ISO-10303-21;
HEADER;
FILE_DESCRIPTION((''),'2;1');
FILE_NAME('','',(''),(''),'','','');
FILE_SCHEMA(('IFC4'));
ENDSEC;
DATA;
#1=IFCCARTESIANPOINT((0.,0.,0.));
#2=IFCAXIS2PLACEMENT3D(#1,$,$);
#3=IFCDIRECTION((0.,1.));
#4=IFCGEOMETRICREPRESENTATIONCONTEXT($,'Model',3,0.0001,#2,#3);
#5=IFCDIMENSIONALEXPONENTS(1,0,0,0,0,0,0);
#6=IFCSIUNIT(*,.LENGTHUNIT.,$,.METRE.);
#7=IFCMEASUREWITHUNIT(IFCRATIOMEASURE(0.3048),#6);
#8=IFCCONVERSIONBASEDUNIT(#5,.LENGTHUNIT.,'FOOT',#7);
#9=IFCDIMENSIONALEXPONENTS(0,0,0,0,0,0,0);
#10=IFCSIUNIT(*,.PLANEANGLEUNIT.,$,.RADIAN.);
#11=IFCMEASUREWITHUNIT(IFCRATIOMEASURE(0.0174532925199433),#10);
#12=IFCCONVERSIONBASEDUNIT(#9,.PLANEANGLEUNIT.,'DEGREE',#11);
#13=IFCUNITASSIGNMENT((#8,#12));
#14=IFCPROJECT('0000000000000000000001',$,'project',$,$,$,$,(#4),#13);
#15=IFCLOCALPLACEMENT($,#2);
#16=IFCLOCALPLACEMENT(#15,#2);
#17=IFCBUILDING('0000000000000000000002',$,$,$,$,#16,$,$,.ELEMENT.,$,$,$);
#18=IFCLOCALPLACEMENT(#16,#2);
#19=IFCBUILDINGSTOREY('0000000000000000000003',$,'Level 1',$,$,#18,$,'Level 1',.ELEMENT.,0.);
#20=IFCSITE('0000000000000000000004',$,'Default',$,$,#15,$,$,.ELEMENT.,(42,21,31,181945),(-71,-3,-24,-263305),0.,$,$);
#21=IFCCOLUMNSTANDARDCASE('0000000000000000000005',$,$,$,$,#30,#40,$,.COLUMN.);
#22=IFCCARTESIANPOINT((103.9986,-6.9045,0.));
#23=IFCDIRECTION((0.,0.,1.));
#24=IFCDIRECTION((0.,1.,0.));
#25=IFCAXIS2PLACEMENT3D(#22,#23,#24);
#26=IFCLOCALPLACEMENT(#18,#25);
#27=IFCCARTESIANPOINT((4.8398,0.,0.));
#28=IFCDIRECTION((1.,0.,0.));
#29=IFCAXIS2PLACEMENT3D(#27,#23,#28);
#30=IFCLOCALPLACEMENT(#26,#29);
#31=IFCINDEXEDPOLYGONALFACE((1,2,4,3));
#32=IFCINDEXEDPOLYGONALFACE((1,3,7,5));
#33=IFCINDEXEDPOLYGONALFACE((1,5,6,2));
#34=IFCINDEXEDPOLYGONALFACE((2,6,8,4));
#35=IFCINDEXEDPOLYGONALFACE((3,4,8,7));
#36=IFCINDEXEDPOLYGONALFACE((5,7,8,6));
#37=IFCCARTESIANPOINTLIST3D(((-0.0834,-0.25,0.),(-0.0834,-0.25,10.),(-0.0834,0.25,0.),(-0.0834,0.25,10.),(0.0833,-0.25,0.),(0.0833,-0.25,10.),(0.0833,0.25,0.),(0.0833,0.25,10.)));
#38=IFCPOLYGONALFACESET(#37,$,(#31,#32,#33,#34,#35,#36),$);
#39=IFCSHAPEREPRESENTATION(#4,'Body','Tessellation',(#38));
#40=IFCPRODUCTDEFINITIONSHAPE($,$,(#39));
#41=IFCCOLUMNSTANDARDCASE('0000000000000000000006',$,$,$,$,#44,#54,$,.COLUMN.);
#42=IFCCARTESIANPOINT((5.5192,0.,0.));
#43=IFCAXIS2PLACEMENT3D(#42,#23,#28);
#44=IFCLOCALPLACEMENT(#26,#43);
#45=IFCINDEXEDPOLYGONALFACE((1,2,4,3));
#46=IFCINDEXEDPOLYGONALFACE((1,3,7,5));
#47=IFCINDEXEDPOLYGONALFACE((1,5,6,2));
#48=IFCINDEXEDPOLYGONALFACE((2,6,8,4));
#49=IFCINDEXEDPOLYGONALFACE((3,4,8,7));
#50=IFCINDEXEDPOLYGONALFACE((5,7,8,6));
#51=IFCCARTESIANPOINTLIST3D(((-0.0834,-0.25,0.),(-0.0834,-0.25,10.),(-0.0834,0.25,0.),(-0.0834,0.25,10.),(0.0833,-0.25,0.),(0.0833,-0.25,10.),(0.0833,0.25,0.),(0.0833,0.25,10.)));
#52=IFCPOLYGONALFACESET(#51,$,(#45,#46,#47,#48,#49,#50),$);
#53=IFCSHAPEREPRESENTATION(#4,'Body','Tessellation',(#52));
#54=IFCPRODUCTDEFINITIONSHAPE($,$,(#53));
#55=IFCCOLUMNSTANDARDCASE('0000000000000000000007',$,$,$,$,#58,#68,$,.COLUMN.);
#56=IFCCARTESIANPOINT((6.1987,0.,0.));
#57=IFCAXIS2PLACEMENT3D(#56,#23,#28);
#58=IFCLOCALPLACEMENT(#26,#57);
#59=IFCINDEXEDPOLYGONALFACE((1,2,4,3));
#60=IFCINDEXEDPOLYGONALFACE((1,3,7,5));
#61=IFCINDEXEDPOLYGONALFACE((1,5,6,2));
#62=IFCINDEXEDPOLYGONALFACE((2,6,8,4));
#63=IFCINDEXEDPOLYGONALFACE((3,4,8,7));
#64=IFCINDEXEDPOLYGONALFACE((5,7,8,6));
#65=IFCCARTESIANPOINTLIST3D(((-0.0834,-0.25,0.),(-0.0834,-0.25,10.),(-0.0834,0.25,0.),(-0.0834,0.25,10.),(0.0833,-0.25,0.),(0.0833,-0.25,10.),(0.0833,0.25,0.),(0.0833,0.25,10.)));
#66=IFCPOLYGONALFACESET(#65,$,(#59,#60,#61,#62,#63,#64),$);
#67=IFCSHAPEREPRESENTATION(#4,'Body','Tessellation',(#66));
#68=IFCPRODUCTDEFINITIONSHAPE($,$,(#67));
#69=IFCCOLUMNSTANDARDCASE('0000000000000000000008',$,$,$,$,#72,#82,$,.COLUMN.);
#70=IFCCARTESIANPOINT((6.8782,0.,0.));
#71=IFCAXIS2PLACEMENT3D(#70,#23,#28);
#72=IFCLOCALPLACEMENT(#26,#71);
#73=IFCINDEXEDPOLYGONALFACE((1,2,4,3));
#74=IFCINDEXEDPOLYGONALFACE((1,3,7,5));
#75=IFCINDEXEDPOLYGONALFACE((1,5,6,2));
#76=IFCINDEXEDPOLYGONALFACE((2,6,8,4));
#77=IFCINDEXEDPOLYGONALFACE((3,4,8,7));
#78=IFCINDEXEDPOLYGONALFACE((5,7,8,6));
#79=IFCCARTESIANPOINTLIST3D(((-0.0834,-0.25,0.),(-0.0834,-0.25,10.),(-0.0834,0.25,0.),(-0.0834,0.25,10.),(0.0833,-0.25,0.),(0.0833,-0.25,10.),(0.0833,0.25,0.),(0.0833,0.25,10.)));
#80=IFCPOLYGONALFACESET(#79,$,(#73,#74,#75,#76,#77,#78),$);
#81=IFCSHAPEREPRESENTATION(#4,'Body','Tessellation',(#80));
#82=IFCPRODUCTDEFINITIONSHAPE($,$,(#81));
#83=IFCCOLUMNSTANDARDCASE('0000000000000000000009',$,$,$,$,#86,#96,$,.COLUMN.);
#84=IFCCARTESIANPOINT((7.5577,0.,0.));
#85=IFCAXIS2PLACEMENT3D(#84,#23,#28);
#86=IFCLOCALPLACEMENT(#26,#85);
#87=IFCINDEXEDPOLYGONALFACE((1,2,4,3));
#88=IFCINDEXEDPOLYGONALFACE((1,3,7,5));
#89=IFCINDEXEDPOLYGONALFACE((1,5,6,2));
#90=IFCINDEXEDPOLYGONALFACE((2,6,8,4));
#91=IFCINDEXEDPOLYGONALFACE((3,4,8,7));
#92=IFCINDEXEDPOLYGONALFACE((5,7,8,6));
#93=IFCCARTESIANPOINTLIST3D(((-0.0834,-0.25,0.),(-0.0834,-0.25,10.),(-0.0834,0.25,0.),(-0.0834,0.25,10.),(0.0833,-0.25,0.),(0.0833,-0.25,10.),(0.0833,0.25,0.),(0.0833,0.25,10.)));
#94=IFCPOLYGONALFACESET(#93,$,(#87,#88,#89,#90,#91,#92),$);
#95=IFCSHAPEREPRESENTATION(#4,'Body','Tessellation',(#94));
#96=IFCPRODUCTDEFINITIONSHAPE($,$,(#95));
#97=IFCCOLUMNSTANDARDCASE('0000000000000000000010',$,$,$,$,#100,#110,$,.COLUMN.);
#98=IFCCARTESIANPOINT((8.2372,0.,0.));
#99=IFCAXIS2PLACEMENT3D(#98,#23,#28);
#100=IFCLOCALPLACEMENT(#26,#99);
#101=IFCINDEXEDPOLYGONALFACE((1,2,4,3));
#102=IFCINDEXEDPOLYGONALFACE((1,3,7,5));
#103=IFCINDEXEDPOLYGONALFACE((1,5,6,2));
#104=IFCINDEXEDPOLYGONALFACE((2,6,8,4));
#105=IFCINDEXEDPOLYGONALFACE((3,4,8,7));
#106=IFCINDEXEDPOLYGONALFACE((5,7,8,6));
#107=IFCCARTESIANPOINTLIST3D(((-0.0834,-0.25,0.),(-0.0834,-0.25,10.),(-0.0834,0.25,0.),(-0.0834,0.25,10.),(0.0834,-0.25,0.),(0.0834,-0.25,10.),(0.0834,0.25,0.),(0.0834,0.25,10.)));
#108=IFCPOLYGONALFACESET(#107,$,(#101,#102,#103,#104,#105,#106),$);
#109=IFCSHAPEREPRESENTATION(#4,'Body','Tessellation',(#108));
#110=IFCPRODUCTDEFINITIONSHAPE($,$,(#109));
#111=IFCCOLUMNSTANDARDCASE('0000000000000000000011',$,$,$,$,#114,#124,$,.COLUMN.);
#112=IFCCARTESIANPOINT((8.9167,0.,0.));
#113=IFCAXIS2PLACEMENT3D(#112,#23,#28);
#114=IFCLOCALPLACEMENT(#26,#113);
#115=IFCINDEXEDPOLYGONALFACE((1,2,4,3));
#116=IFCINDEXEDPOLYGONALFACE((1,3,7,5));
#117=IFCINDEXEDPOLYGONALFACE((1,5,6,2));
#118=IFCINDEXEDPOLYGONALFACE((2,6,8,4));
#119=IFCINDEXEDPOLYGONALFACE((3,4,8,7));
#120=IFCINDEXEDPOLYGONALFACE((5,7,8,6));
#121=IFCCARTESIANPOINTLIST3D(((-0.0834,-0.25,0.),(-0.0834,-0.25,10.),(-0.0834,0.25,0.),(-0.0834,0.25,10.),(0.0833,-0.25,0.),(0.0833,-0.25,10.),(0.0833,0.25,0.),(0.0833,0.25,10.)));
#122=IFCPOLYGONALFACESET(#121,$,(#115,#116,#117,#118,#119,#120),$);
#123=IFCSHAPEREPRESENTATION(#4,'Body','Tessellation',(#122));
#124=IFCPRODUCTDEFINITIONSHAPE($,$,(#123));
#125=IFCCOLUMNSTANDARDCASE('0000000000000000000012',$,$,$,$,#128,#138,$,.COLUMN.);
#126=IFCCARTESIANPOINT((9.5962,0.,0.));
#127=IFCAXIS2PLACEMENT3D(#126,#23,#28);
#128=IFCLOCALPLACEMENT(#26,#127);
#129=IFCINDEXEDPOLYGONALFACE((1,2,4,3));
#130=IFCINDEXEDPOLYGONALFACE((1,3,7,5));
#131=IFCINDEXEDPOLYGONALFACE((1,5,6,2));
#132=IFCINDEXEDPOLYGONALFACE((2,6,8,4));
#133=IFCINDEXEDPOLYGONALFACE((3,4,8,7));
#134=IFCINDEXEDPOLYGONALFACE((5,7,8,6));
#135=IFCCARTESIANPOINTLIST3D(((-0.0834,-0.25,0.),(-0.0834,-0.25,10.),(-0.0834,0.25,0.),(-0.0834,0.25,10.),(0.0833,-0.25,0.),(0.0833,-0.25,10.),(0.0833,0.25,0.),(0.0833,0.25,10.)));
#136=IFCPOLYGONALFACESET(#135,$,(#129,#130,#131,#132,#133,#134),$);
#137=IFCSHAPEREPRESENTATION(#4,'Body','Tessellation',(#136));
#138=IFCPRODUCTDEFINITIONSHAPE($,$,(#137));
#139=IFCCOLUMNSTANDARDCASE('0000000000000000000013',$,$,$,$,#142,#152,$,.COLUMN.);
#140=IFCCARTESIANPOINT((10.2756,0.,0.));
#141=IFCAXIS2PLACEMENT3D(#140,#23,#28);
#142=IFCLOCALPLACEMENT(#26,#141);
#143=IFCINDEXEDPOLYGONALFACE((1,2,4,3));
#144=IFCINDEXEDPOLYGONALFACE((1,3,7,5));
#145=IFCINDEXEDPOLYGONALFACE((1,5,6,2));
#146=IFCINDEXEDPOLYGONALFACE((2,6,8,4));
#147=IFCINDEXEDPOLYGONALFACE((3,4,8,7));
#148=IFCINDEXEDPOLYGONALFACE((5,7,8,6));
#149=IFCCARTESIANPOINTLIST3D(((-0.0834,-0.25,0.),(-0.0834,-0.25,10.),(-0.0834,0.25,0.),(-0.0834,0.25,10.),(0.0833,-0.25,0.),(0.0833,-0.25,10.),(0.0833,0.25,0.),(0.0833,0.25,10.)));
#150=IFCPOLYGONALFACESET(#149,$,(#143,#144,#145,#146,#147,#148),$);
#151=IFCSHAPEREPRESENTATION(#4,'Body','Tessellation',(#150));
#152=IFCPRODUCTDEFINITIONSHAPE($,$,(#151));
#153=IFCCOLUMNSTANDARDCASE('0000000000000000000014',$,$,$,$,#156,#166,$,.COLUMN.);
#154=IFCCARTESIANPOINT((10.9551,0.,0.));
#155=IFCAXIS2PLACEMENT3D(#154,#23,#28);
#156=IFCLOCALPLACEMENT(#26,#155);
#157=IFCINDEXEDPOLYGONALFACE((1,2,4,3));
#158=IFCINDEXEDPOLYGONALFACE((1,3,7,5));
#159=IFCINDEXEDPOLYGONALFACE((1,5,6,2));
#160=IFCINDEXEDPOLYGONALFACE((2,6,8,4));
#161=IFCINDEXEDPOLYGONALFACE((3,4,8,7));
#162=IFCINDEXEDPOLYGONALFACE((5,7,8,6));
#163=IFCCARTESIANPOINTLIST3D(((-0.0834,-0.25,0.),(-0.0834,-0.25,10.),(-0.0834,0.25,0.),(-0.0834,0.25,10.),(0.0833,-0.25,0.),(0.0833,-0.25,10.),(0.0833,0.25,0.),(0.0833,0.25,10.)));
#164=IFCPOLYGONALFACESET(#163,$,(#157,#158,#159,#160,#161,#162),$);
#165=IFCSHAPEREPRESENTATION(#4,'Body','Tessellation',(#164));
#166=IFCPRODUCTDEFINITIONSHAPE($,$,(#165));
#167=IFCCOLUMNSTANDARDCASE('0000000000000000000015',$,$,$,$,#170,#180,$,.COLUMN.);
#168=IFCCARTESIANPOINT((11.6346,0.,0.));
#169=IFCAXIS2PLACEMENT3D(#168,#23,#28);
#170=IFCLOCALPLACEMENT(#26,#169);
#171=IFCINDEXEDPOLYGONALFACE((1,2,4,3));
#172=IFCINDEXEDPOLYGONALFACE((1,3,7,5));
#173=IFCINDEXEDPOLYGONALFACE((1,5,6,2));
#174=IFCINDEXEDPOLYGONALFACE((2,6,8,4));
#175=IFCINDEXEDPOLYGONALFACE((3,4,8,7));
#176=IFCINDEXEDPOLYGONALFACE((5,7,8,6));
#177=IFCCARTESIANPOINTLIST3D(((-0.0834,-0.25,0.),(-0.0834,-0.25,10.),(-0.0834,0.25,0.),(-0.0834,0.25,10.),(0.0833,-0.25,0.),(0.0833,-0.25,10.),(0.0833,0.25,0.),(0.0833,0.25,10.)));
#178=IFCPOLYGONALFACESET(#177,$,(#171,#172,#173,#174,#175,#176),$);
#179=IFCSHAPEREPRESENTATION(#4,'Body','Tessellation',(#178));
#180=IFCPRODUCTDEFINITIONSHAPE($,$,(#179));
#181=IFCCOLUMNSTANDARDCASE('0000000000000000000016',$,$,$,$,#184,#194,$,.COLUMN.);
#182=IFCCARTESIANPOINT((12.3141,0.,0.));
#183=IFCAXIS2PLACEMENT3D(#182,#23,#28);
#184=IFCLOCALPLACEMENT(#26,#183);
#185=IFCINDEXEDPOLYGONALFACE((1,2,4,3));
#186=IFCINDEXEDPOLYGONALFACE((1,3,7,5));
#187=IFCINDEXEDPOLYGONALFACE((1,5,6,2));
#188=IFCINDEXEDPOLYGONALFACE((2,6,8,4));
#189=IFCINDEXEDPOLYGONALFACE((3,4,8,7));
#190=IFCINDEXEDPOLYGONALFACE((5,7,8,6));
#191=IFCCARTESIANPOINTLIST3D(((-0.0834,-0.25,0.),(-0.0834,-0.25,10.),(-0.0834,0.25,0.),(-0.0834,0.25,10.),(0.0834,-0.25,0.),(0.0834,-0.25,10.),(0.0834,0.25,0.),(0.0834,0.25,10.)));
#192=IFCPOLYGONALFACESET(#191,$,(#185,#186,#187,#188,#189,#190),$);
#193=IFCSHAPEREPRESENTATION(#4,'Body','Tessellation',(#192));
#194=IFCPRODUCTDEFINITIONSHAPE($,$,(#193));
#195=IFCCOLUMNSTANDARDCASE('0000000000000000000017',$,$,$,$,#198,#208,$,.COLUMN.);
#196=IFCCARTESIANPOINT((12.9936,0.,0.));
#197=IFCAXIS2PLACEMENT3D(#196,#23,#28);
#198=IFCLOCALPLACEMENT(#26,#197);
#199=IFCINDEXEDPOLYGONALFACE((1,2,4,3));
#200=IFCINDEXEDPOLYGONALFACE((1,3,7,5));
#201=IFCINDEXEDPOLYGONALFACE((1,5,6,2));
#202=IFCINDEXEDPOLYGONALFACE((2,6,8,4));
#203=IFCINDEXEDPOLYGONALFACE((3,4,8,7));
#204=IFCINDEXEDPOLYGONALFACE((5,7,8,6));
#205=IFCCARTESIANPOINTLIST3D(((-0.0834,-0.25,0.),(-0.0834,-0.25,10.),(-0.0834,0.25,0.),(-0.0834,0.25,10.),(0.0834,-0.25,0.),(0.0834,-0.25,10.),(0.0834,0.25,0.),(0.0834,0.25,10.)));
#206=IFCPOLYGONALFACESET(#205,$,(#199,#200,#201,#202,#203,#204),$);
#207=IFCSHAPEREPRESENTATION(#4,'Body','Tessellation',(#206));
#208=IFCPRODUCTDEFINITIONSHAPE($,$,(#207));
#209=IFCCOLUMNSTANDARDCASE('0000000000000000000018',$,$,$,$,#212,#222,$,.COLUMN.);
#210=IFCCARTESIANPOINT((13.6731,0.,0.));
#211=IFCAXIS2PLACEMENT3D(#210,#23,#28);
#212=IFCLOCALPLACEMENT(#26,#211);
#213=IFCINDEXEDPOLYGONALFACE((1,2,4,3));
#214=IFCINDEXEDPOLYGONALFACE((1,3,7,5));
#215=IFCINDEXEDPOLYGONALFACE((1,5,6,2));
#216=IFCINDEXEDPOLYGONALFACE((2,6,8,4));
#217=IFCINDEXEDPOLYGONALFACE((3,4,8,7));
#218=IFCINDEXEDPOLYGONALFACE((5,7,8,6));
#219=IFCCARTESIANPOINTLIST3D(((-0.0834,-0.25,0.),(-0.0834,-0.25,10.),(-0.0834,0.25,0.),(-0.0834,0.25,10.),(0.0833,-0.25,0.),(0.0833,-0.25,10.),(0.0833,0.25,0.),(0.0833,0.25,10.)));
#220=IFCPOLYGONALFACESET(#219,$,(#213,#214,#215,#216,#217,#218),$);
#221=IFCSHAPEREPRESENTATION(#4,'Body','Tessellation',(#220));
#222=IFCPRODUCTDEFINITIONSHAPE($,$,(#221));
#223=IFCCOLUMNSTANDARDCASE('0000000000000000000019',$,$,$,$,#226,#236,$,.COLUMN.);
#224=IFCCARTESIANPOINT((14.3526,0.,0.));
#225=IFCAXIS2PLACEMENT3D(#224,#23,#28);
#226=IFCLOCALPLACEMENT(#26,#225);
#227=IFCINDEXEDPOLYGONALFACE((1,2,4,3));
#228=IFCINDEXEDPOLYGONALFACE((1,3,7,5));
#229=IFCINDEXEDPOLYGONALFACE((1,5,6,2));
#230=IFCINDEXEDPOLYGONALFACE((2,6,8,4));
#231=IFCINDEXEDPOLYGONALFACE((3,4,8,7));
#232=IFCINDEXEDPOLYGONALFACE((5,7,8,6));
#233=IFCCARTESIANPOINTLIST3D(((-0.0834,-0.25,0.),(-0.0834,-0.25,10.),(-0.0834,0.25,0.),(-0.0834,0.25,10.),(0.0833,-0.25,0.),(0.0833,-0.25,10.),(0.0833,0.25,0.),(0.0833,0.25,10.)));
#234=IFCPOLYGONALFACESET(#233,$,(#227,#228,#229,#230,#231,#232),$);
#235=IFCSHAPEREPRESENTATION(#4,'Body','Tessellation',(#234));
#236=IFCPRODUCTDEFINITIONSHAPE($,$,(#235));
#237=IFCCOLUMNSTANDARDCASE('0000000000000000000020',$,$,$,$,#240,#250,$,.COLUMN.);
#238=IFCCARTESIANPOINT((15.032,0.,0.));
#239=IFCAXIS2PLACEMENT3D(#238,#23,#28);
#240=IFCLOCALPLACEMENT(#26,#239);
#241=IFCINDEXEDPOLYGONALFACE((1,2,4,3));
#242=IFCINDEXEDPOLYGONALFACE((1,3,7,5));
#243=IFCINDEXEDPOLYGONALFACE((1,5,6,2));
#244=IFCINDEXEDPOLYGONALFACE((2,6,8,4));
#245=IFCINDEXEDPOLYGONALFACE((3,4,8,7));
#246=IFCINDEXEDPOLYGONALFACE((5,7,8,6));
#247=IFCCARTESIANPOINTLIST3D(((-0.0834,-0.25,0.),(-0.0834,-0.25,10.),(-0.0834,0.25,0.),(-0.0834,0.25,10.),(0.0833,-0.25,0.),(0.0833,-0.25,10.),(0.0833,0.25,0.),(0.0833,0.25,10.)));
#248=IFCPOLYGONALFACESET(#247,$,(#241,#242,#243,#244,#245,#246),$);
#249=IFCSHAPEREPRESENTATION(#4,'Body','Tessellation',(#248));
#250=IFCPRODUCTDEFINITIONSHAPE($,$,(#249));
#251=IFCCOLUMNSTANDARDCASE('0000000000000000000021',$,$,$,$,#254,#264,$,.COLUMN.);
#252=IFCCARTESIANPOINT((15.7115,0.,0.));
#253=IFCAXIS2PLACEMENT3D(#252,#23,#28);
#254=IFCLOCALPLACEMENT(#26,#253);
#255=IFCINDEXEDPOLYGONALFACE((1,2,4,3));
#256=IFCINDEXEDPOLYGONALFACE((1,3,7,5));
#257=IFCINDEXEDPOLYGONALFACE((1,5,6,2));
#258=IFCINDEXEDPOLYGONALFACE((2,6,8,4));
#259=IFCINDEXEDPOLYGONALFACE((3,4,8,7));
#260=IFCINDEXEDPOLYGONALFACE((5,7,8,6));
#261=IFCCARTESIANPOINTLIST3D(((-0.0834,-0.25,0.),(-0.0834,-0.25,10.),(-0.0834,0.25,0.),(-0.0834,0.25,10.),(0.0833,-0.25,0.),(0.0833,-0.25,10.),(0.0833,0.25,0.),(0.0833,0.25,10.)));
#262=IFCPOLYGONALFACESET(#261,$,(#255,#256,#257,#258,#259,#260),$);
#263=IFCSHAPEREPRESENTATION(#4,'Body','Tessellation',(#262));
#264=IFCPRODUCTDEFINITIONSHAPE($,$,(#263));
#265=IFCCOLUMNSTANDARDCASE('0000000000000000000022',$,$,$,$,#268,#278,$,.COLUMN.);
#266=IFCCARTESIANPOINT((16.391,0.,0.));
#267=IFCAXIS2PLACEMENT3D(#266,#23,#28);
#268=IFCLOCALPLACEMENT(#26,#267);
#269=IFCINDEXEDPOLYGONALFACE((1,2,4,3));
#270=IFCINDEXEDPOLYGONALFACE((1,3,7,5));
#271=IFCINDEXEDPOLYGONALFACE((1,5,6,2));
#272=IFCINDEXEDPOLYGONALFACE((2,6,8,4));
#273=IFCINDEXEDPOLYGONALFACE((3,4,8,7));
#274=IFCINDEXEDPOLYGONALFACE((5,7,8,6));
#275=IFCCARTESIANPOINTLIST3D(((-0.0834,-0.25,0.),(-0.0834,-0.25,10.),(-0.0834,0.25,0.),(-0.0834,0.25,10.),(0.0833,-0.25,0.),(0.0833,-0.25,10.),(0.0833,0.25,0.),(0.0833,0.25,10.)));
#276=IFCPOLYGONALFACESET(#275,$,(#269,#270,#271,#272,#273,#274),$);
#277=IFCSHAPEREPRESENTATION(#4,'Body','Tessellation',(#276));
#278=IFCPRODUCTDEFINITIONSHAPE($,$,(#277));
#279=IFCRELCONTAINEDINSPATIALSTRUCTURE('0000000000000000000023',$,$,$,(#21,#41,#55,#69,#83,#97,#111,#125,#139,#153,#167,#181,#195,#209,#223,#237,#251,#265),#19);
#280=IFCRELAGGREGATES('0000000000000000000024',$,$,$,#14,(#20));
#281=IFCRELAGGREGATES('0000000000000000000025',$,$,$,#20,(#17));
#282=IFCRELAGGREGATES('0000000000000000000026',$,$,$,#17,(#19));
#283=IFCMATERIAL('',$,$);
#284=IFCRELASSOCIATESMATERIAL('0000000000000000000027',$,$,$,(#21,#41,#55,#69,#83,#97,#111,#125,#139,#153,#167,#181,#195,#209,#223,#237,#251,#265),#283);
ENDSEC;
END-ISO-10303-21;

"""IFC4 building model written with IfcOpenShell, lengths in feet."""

from ifc_helpers import new_model, entity, si_unit, converted_unit, direction, frame, origin, place, context, project, spatial, rectangle, extrude, material, element, save


model = new_model("IFC4")

# Units and contexts
model_context = context("Model", 3, precision=0.0001, world=origin(), true_north=direction((0.0, 1.0)))
ifc_project = project(units=[converted_unit("LENGTHUNIT", "FOOT", entity("IfcRatioMeasure", 0.3048), si_unit("LENGTHUNIT", "METRE"), dimensions=[1, 0, 0, 0, 0, 0, 0]), converted_unit("PLANEANGLEUNIT", "DEGREE", entity("IfcRatioMeasure", 0.0174532925199433), si_unit("PLANEANGLEUNIT", "RADIAN"), dimensions=[0, 0, 0, 0, 0, 0, 0])], contexts=[model_context])

# Site, building, storey
site_placement = place(None, origin())
site = spatial("IfcSite", under=ifc_project, at=site_placement, Name="Default", CompositionType="ELEMENT", RefLatitude=(42, 21, 31, 181945), RefLongitude=(-71, -3, -24, -263305), RefElevation=0.0)
building_placement = place(site_placement, origin())
building = spatial("IfcBuilding", under=site, at=building_placement, CompositionType="ELEMENT")
storey_placement = place(building_placement, origin())
storey = spatial("IfcBuildingStorey", under=building, at=storey_placement, Name="Level 1", LongName="Level 1", CompositionType="ELEMENT", Elevation=0.0)

# Columns
ifc_material_1 = material(Name="")
placement = place(storey_placement, frame((103.9986, -6.9045, 0.0), z_axis=(0.0, 0.0, 1.0), x_axis=(0.0, 1.0, 0.0)))
for number, where, z_axis, x_axis in (
    (1, (4.8398, 0.0, 0.0), (0.0, 0.0, 1.0), (1.0, 0.0, 0.0)),
    (2, (5.5192, 0.0, 0.0), (0.0, 0.0, 1.0), (1.0, 0.0, 0.0)),
    (3, (6.1987, 0.0, 0.0), (0.0, 0.0, 1.0), (1.0, 0.0, 0.0)),
    (4, (6.8782, 0.0, 0.0), (0.0, 0.0, 1.0), (1.0, 0.0, 0.0)),
    (5, (7.5577, 0.0, 0.0), (0.0, 0.0, 1.0), (1.0, 0.0, 0.0)),
    (6, (8.2372, 0.0, 0.0), (0.0, 0.0, 1.0), (1.0, 0.0, 0.0)),
    (7, (8.9167, 0.0, 0.0), (0.0, 0.0, 1.0), (1.0, 0.0, 0.0)),
    (8, (9.5962, 0.0, 0.0), (0.0, 0.0, 1.0), (1.0, 0.0, 0.0)),
    (9, (10.2756, 0.0, 0.0), (0.0, 0.0, 1.0), (1.0, 0.0, 0.0)),
    (10, (10.9551, 0.0, 0.0), (0.0, 0.0, 1.0), (1.0, 0.0, 0.0)),
    (11, (11.6346, 0.0, 0.0), (0.0, 0.0, 1.0), (1.0, 0.0, 0.0)),
    (12, (12.3141, 0.0, 0.0), (0.0, 0.0, 1.0), (1.0, 0.0, 0.0)),
    (13, (12.9936, 0.0, 0.0), (0.0, 0.0, 1.0), (1.0, 0.0, 0.0)),
    (14, (13.6731, 0.0, 0.0), (0.0, 0.0, 1.0), (1.0, 0.0, 0.0)),
    (15, (14.3526, 0.0, 0.0), (0.0, 0.0, 1.0), (1.0, 0.0, 0.0)),
    (16, (15.032, 0.0, 0.0), (0.0, 0.0, 1.0), (1.0, 0.0, 0.0)),
    (17, (15.7115, 0.0, 0.0), (0.0, 0.0, 1.0), (1.0, 0.0, 0.0)),
    (18, (16.391, 0.0, 0.0), (0.0, 0.0, 1.0), (1.0, 0.0, 0.0)),
):
    element("IfcColumnStandardCase", number, at=place(placement, frame(where, z_axis=z_axis, x_axis=x_axis)), inside=storey, material=ifc_material_1, PredefinedType="COLUMN", context=model_context, shape_type="SweptSolid", body=[
        extrude(rectangle(XDim=0.1667, YDim=0.5), origin(), (0.0, 0.0, 1.0), 10.0),
    ])

save(model, "model.ifc")
